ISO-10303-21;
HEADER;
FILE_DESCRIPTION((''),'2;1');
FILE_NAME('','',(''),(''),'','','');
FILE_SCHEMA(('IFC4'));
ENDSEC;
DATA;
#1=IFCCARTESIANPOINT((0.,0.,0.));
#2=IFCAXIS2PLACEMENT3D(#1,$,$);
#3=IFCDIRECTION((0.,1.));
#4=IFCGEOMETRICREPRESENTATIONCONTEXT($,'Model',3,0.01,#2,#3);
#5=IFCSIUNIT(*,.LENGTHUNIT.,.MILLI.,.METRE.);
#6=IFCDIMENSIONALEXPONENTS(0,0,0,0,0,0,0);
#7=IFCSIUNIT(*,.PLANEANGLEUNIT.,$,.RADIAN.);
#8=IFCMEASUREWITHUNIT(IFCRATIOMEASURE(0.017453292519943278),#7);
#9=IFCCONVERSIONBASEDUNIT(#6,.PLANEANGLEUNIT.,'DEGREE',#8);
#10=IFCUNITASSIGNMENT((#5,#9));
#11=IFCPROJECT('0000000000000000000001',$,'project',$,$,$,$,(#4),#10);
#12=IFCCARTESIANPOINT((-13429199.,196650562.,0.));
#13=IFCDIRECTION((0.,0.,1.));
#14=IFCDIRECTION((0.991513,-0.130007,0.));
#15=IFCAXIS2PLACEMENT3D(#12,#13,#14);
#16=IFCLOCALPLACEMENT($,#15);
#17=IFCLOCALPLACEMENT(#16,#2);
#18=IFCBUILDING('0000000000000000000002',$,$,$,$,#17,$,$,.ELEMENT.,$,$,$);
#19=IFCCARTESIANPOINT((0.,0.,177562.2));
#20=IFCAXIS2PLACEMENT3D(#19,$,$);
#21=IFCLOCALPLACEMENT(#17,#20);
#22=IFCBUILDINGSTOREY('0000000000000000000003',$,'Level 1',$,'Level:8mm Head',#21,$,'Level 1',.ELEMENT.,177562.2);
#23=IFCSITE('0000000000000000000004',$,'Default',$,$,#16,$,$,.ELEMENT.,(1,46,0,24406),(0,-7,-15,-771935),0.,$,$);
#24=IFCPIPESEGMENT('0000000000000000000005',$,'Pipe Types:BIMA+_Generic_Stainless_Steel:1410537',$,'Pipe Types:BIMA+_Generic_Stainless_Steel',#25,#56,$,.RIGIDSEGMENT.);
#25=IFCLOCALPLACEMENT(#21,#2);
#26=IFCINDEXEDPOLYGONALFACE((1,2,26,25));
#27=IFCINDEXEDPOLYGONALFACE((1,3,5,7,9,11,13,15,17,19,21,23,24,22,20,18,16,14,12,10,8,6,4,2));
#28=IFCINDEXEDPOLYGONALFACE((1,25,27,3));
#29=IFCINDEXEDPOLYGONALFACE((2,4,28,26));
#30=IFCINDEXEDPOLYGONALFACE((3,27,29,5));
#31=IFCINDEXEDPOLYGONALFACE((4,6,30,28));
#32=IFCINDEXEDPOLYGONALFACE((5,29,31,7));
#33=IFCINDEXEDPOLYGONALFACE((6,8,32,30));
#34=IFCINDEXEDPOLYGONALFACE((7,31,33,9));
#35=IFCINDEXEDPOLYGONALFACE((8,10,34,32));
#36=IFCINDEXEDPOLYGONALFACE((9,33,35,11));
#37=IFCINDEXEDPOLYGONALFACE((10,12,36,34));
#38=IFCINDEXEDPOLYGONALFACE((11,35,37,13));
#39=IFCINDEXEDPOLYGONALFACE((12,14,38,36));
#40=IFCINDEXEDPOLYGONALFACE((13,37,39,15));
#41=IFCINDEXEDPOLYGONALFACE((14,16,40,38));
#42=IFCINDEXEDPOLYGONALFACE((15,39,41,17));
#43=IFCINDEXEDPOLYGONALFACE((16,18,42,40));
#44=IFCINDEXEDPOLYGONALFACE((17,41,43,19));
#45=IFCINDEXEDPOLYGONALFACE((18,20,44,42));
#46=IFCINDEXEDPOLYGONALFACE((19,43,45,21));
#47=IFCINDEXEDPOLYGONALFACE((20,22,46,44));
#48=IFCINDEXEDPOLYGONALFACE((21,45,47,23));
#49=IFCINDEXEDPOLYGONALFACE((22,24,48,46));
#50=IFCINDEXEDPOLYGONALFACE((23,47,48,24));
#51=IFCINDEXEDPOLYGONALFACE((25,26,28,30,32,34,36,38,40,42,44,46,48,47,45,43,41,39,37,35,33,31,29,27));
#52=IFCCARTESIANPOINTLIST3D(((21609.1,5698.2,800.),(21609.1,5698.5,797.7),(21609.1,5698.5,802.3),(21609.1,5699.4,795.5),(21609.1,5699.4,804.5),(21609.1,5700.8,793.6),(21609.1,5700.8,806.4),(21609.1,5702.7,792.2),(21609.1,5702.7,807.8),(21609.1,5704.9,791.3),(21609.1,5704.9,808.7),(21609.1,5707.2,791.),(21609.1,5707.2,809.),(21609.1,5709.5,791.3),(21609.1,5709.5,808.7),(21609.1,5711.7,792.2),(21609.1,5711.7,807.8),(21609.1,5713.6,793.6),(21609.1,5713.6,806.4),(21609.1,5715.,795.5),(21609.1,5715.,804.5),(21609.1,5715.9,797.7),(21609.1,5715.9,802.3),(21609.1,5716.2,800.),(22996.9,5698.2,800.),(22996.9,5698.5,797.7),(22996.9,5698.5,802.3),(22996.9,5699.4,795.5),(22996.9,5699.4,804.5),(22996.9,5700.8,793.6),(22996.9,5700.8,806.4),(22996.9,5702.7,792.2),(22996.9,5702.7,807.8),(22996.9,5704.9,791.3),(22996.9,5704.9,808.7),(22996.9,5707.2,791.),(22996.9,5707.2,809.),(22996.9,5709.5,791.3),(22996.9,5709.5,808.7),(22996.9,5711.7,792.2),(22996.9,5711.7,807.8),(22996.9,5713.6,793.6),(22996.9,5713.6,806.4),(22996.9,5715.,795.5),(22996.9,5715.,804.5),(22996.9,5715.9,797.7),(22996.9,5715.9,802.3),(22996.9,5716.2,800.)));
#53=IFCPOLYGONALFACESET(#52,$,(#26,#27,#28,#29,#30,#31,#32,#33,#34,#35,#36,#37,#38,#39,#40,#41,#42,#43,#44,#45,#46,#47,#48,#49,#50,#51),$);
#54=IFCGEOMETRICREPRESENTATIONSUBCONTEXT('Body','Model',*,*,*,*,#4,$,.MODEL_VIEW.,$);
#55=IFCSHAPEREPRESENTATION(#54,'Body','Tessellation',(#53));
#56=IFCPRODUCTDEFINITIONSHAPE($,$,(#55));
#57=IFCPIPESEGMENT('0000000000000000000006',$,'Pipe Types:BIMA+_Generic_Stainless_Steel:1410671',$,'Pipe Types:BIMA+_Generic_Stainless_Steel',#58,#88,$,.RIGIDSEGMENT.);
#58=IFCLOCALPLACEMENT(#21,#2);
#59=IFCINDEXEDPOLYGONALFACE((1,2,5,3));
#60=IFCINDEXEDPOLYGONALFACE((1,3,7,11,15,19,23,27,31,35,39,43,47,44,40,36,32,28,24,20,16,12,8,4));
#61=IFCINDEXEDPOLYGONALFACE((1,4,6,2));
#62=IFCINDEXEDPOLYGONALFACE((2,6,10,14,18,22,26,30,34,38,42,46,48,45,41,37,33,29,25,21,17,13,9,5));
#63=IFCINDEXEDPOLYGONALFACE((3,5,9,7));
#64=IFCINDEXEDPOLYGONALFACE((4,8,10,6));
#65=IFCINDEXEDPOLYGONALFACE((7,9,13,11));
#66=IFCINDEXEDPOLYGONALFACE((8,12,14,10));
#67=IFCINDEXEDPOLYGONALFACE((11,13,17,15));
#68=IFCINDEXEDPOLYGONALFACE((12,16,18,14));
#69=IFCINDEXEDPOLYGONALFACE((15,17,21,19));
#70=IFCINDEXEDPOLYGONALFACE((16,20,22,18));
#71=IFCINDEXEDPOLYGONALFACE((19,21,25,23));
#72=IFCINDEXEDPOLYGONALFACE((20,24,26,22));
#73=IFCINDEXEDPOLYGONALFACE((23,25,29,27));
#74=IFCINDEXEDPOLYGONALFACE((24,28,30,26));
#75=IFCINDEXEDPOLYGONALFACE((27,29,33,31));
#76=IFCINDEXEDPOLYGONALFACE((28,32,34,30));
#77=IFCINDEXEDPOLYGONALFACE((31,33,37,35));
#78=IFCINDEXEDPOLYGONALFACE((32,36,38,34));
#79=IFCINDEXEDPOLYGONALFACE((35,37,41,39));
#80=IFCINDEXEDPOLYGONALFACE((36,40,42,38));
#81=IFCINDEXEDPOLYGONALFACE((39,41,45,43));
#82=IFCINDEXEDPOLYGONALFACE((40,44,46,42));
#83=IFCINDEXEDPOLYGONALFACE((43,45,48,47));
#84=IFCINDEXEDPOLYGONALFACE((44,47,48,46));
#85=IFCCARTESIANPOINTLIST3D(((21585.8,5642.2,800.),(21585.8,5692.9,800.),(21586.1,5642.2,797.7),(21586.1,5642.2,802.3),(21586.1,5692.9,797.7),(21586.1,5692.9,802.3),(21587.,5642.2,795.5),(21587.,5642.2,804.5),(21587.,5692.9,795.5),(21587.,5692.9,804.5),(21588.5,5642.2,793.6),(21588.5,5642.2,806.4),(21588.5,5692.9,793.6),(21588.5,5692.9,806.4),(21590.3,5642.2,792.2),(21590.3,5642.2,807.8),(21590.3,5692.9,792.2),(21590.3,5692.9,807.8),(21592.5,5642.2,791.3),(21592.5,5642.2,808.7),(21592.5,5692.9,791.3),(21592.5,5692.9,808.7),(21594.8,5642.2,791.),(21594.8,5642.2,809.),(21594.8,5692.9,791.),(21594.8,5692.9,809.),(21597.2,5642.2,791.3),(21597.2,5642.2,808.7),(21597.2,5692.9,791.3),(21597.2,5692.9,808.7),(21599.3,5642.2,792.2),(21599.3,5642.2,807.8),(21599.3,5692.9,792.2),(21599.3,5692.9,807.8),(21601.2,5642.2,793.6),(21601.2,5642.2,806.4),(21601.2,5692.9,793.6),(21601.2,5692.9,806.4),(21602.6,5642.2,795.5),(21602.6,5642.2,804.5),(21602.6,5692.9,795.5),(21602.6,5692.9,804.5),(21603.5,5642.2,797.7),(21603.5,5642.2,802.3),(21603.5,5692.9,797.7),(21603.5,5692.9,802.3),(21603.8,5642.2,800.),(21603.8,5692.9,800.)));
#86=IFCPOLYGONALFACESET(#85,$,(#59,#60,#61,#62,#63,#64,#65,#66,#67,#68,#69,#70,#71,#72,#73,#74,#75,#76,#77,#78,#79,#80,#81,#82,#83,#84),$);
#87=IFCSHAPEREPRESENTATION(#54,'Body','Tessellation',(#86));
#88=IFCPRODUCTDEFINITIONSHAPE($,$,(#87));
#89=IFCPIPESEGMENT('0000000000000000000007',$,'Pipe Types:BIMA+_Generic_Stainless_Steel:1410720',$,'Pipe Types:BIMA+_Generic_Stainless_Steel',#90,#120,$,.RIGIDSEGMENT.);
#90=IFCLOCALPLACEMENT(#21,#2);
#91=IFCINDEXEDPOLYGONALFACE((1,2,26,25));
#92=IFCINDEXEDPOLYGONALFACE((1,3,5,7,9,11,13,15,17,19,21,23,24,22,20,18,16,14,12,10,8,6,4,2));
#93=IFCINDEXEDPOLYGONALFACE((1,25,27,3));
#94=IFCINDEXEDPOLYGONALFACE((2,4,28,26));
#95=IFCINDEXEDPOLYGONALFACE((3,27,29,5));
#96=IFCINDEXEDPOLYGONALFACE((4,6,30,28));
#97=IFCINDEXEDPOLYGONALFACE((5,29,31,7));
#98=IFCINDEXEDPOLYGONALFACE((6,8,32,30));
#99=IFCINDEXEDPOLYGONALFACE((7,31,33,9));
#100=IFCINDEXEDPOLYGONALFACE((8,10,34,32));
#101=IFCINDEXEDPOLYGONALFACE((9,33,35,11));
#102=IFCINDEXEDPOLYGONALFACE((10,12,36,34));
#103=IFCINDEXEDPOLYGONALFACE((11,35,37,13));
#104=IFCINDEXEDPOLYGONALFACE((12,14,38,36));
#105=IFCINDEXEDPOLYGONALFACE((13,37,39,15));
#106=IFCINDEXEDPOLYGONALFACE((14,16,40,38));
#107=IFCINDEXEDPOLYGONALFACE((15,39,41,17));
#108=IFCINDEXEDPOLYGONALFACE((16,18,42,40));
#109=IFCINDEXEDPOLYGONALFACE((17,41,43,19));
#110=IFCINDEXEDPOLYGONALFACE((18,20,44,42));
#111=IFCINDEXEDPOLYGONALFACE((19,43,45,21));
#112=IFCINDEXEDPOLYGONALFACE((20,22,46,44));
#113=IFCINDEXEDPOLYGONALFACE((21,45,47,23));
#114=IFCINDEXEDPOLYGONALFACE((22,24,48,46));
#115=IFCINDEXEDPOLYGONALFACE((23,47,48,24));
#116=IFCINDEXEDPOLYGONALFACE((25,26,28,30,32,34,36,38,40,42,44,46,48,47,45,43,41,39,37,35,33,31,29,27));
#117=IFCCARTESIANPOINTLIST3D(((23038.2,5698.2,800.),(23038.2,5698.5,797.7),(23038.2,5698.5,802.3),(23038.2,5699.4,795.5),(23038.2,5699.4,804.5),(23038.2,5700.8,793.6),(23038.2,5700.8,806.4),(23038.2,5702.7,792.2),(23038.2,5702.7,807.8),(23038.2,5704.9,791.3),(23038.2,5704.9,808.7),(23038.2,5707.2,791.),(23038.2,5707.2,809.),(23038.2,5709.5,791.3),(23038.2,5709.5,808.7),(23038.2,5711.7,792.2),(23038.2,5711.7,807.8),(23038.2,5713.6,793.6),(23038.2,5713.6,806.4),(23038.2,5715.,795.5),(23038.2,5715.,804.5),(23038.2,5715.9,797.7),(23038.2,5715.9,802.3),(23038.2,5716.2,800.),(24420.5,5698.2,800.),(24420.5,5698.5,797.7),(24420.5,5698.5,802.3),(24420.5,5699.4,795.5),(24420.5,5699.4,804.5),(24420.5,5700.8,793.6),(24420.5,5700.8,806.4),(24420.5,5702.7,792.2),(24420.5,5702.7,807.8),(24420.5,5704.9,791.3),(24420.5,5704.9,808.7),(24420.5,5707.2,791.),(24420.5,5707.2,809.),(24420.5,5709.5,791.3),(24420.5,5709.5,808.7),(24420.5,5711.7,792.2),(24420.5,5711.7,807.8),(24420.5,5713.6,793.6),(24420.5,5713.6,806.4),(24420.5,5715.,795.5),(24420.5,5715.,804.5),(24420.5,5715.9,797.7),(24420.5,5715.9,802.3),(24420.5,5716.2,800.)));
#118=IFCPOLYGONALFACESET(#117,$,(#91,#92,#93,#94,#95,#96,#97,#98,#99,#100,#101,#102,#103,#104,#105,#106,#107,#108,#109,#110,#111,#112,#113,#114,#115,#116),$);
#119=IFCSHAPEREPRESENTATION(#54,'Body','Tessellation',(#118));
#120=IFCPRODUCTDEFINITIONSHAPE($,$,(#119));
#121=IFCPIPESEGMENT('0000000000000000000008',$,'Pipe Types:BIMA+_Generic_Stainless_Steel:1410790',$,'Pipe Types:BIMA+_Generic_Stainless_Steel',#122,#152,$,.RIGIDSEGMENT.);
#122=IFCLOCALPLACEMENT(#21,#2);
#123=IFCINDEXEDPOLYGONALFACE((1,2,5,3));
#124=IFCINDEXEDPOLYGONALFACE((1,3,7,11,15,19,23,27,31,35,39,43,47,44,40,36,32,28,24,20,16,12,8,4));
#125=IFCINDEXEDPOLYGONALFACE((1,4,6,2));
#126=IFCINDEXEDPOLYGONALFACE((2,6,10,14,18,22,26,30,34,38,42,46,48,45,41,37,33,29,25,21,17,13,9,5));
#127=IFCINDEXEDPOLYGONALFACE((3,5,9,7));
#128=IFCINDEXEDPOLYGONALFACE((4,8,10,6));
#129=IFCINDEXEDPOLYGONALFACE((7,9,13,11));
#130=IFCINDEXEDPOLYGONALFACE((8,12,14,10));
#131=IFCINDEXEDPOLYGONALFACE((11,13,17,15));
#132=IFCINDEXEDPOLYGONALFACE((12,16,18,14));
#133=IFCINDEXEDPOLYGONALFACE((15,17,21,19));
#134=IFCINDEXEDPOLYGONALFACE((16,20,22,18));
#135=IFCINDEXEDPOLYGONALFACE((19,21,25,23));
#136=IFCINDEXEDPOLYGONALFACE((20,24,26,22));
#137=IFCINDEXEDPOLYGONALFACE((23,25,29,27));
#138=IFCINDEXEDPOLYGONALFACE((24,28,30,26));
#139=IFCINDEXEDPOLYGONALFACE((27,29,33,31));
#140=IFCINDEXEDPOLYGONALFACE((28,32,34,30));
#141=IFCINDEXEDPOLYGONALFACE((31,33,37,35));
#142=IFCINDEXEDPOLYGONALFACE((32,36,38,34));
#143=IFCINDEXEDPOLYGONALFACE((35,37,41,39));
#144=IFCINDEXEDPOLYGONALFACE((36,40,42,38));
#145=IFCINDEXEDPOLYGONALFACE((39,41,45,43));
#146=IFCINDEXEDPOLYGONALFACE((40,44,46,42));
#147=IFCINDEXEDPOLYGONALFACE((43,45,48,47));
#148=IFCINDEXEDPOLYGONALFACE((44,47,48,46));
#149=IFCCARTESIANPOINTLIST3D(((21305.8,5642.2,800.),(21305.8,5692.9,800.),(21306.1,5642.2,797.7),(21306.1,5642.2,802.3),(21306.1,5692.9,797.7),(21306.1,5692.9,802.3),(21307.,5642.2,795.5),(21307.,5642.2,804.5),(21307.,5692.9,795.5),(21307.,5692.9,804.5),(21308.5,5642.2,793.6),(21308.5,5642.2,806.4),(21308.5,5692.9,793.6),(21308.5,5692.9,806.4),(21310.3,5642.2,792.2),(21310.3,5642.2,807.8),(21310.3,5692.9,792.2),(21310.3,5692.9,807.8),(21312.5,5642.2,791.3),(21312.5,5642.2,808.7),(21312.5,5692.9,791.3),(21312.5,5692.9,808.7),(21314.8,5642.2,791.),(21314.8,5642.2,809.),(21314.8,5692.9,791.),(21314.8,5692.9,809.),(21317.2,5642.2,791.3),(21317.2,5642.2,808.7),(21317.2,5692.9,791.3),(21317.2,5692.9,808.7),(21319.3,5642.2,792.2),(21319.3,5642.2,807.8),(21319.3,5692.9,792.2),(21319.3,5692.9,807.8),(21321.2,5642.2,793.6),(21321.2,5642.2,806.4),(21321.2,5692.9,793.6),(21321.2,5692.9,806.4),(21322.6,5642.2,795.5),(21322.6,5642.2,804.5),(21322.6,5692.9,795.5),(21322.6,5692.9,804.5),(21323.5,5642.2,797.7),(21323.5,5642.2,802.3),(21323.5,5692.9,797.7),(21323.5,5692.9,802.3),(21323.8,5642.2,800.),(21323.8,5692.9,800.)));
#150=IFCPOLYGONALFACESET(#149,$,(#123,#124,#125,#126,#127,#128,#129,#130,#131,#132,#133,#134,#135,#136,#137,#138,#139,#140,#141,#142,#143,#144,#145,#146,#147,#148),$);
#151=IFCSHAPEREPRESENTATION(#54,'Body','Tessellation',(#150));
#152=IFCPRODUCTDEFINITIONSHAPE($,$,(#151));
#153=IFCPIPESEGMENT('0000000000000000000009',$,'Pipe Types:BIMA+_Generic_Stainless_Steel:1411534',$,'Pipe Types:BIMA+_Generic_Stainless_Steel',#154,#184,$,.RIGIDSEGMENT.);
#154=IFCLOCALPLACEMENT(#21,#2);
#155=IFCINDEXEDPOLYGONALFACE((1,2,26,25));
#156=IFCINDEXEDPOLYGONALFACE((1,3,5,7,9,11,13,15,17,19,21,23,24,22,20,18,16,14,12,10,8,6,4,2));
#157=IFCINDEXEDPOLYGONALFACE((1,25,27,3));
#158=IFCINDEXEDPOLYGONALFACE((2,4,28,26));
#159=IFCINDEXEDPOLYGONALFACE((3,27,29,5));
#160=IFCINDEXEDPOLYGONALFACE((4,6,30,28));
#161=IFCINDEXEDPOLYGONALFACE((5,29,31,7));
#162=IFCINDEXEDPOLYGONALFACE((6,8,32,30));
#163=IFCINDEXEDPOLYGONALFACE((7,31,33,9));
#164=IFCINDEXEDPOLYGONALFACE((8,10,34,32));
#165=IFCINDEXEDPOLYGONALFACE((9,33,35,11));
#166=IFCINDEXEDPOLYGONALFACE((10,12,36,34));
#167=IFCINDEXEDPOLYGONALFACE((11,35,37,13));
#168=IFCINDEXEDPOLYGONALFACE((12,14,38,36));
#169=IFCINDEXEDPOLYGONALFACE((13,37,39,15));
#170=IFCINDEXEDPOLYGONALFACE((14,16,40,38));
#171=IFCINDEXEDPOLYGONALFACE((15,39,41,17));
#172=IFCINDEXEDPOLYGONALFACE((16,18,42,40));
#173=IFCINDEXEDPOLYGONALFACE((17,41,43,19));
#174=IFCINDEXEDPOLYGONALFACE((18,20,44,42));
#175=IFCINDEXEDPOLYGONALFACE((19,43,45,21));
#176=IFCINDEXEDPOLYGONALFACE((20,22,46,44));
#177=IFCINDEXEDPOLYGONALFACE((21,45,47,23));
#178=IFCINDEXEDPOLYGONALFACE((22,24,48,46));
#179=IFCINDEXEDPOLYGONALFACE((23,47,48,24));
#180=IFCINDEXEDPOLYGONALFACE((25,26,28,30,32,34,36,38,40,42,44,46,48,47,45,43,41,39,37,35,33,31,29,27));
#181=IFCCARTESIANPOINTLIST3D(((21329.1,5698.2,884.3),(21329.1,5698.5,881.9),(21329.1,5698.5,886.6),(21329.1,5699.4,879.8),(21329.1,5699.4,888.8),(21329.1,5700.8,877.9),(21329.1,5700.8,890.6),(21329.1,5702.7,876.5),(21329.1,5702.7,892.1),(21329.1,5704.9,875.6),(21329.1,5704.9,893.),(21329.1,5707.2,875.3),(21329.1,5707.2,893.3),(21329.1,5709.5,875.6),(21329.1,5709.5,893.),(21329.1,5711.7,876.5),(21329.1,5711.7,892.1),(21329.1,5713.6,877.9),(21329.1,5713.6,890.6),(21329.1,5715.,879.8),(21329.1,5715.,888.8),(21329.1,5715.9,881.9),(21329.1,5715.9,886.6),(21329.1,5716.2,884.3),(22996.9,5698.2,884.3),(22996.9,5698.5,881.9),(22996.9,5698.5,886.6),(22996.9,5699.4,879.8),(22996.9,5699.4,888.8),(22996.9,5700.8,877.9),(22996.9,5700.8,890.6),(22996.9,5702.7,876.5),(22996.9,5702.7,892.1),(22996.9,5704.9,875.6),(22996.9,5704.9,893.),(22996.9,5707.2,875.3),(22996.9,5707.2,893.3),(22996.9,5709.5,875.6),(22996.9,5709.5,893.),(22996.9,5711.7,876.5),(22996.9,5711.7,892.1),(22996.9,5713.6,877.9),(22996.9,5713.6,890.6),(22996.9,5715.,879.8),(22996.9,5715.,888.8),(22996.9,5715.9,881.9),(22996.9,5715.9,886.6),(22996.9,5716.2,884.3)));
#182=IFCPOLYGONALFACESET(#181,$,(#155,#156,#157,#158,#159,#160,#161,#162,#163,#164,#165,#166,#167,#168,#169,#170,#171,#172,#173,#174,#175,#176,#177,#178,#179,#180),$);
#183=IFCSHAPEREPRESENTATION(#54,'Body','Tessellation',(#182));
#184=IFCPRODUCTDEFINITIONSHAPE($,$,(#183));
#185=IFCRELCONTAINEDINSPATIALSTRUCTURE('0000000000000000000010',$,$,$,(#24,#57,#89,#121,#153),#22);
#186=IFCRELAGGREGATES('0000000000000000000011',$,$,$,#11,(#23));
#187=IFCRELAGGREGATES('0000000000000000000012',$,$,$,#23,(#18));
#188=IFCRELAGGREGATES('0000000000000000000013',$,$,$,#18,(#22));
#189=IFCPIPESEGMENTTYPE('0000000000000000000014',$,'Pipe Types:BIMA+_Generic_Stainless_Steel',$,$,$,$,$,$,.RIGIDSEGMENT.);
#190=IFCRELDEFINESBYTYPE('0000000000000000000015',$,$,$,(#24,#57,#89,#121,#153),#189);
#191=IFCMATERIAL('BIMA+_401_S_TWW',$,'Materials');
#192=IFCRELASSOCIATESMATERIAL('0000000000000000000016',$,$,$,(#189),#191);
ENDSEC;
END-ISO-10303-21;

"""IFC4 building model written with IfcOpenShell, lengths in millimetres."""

from ifc_helpers import new_model, entity, si_unit, converted_unit, direction, frame, origin, place, context, subcontext, project, spatial, arc, indexed_curve, outline, extrude, material, type_object, element, save


model = new_model("IFC4")

# Units and contexts
model_context = context("Model", 3, precision=0.01, world=origin(), true_north=direction((0.0, 1.0)))
body_context = subcontext(model_context, "Body", "Model", "MODEL_VIEW")
ifc_project = project(units=[si_unit("LENGTHUNIT", "METRE", prefix="MILLI"), converted_unit("PLANEANGLEUNIT", "DEGREE", entity("IfcRatioMeasure", 0.017453292519943278), si_unit("PLANEANGLEUNIT", "RADIAN"), dimensions=[0, 0, 0, 0, 0, 0, 0])], contexts=[model_context])

# Site, building, storey
site_placement = place(None, frame((-13429199.0, 196650562.0, 0.0), z_axis=(0.0, 0.0, 1.0), x_axis=(0.991513, -0.130007, 0.0)))
site = spatial("IfcSite", under=ifc_project, at=site_placement, Name="Default", CompositionType="ELEMENT", RefLatitude=(1, 46, 0, 24406), RefLongitude=(0, -7, -15, -771935), RefElevation=0.0)
building_placement = place(site_placement, origin())
building = spatial("IfcBuilding", under=site, at=building_placement, CompositionType="ELEMENT")
storey_placement = place(building_placement, frame((0.0, 0.0, 177562.2)))
storey = spatial("IfcBuildingStorey", under=building, at=storey_placement, Name="Level 1", ObjectType="Level:8mm Head", LongName="Level 1", CompositionType="ELEMENT", Elevation=177562.2)

# Pipe segments
ifc_material_1 = material(Name="BIMA+_401_S_TWW", Category="Materials")
pipe_segment_type_1 = type_object("IfcPipeSegmentType", Name="Pipe Types:BIMA+_Generic_Stainless_Steel", PredefinedType="RIGIDSEGMENT", material=ifc_material_1)
pipe_segment_1_placement = place(storey_placement, frame((21609.1, 5696.6, 789.4)))
element("IfcPipeSegment", 1, at=pipe_segment_1_placement, inside=storey, type_object=pipe_segment_type_1, Name="Pipe Types:BIMA+_Generic_Stainless_Steel:1410537", ObjectType="Pipe Types:BIMA+_Generic_Stainless_Steel", PredefinedType="RIGIDSEGMENT", context=body_context, shape_type="SweptSolid", body=[
    extrude(outline(indexed_curve([(9.0, 0.0), (6.4, 6.4), (0.0, 9.0), (-6.4, 6.4), (-9.0, 0.0), (-6.4, -6.4), (0.0, -9.0), (6.4, -6.4)], segments=[arc(1, 2, 3), arc(3, 4, 5), arc(5, 6, 7), arc(7, 8, 1)], self_intersect=False)), frame((0.0, 10.6, 10.6), z_axis=(1.0, 0.0, 0.0), x_axis=(0.0, 1.0, 0.0)), (0.0, 0.0, 1.0), 1387.8),
])
pipe_segment_2_placement = place(storey_placement, frame((21584.2, 5642.2, 789.4)))
element("IfcPipeSegment", 2, at=pipe_segment_2_placement, inside=storey, type_object=pipe_segment_type_1, Name="Pipe Types:BIMA+_Generic_Stainless_Steel:1410671", ObjectType="Pipe Types:BIMA+_Generic_Stainless_Steel", PredefinedType="RIGIDSEGMENT", context=body_context, shape_type="SweptSolid", body=[
    extrude(outline(indexed_curve([(9.0, 0.0), (6.4, 6.4), (0.0, 9.0), (-6.4, 6.4), (-9.0, 0.0), (-6.4, -6.4), (0.0, -9.0), (6.4, -6.4)], segments=[arc(1, 2, 3), arc(3, 4, 5), arc(5, 6, 7), arc(7, 8, 1)], self_intersect=False)), frame((10.6, 0.0, 10.6), z_axis=(0.0, 1.0, 0.0), x_axis=(-1.0, 0.0, 0.0)), (0.0, 0.0, 1.0), 50.7),
])
pipe_segment_3_placement = place(storey_placement, frame((23038.2, 5696.6, 789.4)))
element("IfcPipeSegment", 3, at=pipe_segment_3_placement, inside=storey, type_object=pipe_segment_type_1, Name="Pipe Types:BIMA+_Generic_Stainless_Steel:1410720", ObjectType="Pipe Types:BIMA+_Generic_Stainless_Steel", PredefinedType="RIGIDSEGMENT", context=body_context, shape_type="SweptSolid", body=[
    extrude(outline(indexed_curve([(9.0, 0.0), (6.4, 6.4), (0.0, 9.0), (-6.4, 6.4), (-9.0, 0.0), (-6.4, -6.4), (0.0, -9.0), (6.4, -6.4)], segments=[arc(1, 2, 3), arc(3, 4, 5), arc(5, 6, 7), arc(7, 8, 1)], self_intersect=False)), frame((0.0, 10.6, 10.6), z_axis=(1.0, 0.0, 0.0), x_axis=(0.0, 1.0, 0.0)), (0.0, 0.0, 1.0), 1382.4),
])
pipe_segment_4_placement = place(storey_placement, frame((21304.2, 5642.2, 789.4)))
element("IfcPipeSegment", 4, at=pipe_segment_4_placement, inside=storey, type_object=pipe_segment_type_1, Name="Pipe Types:BIMA+_Generic_Stainless_Steel:1410790", ObjectType="Pipe Types:BIMA+_Generic_Stainless_Steel", PredefinedType="RIGIDSEGMENT", context=body_context, shape_type="SweptSolid", body=[
    extrude(outline(indexed_curve([(9.0, 0.0), (6.4, 6.4), (0.0, 9.0), (-6.4, 6.4), (-9.0, 0.0), (-6.4, -6.4), (0.0, -9.0), (6.4, -6.4)], segments=[arc(1, 2, 3), arc(3, 4, 5), arc(5, 6, 7), arc(7, 8, 1)], self_intersect=False)), frame((10.6, 0.0, 10.6), z_axis=(0.0, 1.0, 0.0), x_axis=(1.0, 0.0, 0.0)), (0.0, 0.0, 1.0), 50.7),
])
pipe_segment_5_placement = place(storey_placement, frame((21329.1, 5696.6, 873.7)))
element("IfcPipeSegment", 5, at=pipe_segment_5_placement, inside=storey, type_object=pipe_segment_type_1, Name="Pipe Types:BIMA+_Generic_Stainless_Steel:1411534", ObjectType="Pipe Types:BIMA+_Generic_Stainless_Steel", PredefinedType="RIGIDSEGMENT", context=body_context, shape_type="SweptSolid", body=[
    extrude(outline(indexed_curve([(9.0, 0.0), (6.4, 6.4), (0.0, 9.0), (-6.4, 6.4), (-9.0, 0.0), (-6.4, -6.4), (0.0, -9.0), (6.4, -6.4)], segments=[arc(1, 2, 3), arc(3, 4, 5), arc(5, 6, 7), arc(7, 8, 1)], self_intersect=False)), frame((0.0, 10.6, 10.6), z_axis=(1.0, 0.0, 0.0), x_axis=(0.0, 1.0, 0.0)), (0.0, 0.0, 1.0), 1667.8),
])

save(model, "model.ifc")
